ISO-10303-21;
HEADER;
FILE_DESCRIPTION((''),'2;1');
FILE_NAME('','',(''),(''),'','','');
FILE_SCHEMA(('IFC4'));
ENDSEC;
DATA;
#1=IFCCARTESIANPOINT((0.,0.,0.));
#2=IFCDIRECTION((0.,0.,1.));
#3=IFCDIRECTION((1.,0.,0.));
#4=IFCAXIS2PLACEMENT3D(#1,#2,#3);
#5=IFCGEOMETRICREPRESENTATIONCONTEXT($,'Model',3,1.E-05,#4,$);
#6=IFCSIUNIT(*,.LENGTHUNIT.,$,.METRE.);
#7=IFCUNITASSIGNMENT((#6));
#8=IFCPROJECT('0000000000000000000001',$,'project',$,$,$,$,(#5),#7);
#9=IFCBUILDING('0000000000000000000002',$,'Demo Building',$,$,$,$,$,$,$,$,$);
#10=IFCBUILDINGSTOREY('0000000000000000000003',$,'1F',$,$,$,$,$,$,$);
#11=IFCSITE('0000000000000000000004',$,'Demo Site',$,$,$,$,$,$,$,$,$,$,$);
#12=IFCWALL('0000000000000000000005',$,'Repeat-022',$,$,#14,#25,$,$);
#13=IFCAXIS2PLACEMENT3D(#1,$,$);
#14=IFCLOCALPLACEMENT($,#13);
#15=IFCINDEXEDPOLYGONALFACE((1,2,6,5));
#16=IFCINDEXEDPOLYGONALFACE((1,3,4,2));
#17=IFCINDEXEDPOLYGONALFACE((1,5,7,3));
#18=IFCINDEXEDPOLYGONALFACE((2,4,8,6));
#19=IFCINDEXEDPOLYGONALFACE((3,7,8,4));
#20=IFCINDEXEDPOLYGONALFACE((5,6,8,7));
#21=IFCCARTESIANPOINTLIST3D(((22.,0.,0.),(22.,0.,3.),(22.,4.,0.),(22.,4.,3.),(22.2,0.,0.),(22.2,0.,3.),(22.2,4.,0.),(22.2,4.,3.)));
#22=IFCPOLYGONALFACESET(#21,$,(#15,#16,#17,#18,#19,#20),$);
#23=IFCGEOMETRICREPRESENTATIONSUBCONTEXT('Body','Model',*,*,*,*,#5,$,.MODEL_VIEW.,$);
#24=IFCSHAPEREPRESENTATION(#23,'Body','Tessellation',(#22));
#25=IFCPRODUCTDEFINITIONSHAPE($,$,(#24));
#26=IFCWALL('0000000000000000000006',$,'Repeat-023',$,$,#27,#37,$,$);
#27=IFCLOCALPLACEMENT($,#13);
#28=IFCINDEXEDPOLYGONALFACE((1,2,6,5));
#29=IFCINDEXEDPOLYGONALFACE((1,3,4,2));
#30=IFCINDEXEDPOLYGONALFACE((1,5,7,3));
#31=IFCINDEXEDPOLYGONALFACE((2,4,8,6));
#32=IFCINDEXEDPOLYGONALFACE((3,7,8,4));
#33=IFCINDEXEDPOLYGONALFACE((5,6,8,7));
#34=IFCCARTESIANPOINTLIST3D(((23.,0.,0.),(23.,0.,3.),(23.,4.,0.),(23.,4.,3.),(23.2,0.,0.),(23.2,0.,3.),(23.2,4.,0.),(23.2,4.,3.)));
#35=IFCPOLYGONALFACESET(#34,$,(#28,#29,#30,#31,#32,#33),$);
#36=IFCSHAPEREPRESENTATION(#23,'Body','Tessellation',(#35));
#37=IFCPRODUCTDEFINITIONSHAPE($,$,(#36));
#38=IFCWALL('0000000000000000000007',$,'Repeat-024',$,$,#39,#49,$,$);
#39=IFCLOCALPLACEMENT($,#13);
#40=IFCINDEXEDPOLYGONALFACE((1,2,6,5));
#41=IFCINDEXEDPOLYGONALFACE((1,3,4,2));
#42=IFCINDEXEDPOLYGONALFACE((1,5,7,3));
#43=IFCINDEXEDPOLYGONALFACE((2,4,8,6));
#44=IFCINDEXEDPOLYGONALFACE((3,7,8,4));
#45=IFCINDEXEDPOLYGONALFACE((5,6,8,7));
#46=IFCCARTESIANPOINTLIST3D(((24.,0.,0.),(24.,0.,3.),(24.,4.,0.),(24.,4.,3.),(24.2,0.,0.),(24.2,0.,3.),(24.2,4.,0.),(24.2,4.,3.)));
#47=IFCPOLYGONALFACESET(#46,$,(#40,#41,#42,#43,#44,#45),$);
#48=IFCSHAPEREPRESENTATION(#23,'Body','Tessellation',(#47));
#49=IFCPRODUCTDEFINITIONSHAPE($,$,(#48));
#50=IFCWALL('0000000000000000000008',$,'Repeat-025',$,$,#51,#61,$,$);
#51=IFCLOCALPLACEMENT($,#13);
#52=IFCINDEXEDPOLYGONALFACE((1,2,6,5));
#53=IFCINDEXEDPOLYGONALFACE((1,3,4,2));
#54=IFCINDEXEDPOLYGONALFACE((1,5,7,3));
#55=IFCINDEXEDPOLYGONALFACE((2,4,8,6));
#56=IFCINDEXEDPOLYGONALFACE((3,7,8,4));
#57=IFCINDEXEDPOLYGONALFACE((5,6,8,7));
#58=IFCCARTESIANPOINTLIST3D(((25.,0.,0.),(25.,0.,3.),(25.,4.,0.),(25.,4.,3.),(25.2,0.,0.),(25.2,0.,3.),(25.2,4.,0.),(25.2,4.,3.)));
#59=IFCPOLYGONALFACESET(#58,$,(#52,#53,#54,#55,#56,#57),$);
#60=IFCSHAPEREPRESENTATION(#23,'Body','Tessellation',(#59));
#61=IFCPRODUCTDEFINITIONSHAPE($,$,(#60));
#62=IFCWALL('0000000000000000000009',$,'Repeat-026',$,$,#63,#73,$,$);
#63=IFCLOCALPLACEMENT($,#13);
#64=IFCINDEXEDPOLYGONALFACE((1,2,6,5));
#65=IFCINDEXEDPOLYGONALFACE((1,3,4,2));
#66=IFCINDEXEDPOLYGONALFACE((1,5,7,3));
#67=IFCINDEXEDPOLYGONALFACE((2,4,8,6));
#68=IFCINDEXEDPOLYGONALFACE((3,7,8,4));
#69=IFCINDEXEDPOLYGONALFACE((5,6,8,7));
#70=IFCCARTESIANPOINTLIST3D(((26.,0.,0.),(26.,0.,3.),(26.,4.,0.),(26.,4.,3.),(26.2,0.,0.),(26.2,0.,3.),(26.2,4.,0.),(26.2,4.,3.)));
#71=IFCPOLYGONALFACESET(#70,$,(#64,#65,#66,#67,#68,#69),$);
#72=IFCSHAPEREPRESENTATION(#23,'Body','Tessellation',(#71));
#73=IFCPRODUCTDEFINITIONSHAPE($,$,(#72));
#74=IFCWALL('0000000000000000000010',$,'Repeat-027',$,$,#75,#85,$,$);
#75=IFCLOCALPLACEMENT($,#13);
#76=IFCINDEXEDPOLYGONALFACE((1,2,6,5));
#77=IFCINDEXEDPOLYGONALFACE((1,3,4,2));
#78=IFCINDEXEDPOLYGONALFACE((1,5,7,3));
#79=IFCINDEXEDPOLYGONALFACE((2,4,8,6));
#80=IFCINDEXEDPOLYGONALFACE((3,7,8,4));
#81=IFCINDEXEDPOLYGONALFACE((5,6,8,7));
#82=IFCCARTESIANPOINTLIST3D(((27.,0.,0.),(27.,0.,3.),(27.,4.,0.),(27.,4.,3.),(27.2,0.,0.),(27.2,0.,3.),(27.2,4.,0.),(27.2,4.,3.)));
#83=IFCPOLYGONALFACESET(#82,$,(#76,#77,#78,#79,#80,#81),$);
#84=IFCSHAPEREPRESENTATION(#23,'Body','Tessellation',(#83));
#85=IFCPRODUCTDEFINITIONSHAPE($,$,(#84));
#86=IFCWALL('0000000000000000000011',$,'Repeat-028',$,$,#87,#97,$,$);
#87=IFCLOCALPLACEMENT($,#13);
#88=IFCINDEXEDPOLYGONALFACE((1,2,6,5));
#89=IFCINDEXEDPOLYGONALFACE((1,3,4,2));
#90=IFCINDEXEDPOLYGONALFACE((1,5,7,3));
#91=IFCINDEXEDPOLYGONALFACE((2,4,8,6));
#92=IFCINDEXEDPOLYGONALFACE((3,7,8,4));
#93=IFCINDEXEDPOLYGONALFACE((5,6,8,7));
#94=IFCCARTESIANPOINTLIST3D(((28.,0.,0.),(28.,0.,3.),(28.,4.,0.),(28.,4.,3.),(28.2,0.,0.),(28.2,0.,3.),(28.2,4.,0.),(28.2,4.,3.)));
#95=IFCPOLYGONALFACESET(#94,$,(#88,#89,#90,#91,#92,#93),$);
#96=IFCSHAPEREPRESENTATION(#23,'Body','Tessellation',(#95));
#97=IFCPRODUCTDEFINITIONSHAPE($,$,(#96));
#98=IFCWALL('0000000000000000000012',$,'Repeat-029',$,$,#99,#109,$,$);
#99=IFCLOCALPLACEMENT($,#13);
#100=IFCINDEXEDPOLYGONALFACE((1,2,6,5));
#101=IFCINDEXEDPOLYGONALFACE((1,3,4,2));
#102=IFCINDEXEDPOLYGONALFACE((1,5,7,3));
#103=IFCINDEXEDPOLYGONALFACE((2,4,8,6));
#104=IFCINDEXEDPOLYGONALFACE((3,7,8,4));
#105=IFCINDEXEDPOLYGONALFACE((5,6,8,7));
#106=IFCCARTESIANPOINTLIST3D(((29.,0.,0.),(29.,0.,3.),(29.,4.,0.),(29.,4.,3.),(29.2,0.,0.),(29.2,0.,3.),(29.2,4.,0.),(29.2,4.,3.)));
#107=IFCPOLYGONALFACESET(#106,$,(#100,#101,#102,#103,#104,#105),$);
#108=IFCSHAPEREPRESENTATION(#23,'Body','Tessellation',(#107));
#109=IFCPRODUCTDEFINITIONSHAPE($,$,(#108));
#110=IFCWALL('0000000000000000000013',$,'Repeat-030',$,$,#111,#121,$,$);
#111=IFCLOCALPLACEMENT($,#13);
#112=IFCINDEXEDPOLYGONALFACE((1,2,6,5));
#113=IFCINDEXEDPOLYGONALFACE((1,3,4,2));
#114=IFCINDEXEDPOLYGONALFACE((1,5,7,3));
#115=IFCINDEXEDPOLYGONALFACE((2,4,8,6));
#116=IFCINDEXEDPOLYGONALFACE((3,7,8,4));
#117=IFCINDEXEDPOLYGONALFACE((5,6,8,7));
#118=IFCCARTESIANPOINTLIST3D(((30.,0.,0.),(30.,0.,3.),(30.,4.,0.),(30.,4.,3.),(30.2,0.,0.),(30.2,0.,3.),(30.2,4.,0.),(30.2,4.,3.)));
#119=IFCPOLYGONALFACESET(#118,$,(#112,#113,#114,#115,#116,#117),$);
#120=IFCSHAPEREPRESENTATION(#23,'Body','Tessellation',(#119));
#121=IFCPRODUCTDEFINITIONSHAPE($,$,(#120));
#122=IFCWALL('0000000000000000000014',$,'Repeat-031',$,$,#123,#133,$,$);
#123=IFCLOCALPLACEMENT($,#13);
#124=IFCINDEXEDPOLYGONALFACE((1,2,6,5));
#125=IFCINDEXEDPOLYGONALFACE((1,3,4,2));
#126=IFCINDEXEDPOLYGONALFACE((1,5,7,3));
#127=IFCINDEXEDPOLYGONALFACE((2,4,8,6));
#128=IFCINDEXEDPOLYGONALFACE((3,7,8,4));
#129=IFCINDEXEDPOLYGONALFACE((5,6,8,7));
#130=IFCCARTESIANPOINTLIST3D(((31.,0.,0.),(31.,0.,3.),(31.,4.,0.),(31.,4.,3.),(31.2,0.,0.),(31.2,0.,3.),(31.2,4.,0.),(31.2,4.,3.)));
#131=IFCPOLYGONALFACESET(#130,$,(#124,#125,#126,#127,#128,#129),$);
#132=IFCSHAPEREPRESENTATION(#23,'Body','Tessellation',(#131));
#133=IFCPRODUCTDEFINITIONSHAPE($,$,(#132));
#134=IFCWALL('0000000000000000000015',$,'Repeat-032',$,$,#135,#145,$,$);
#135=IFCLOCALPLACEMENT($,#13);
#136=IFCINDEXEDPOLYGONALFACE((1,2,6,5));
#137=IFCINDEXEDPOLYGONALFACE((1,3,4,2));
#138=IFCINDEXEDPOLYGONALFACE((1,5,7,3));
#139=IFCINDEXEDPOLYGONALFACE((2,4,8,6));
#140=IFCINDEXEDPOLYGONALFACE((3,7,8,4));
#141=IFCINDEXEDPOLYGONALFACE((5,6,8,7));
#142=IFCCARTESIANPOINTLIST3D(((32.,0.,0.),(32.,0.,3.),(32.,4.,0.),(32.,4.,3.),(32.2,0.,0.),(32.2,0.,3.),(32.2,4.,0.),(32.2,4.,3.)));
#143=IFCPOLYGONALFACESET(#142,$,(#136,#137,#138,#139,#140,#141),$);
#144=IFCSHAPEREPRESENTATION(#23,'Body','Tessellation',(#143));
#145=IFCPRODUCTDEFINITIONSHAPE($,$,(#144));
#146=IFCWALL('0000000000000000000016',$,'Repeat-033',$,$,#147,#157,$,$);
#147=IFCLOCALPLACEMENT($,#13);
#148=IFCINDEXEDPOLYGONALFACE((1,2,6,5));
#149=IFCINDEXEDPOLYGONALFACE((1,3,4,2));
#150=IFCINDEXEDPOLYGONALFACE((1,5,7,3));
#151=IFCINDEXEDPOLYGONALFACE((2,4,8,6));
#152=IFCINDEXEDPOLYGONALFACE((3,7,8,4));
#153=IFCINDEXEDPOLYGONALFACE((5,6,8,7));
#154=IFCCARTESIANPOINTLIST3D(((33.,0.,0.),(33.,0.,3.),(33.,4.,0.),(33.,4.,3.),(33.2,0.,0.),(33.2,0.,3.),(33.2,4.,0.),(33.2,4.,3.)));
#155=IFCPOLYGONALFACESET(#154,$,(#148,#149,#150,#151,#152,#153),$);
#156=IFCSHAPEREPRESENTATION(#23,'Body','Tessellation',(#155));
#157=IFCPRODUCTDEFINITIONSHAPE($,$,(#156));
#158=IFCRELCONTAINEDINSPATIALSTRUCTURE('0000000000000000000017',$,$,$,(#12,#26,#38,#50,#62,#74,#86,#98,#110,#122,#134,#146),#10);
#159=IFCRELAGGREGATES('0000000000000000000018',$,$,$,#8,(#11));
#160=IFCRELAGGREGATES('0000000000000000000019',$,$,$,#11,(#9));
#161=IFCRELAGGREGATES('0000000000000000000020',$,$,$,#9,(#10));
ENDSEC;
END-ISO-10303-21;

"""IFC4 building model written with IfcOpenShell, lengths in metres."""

from ifc_helpers import new_model, entity, si_unit, frame, origin_with_axes, place, context, subcontext, project, spatial, element, save


model = new_model("IFC4")

# Units and contexts
model_context = context("Model", 3, precision=1e-05, world=origin_with_axes())
body_context = subcontext(model_context, "Body", "Model", "MODEL_VIEW")
ifc_project = project(units=[si_unit("LENGTHUNIT", "METRE")], contexts=[model_context])

# Site, building, storey
site = spatial("IfcSite", under=ifc_project, Name="Demo Site")
building = spatial("IfcBuilding", under=site, Name="Demo Building")
storey = spatial("IfcBuildingStorey", under=building, Name="1F")

# Walls
for number, where, z_axis, x_axis, name in (
    (1, (22.0, 0.0, 0.0), (0.0, 0.0, 1.0), (1.0, 0.0, 0.0), "Repeat-022"),
    (2, (23.0, 0.0, 0.0), (0.0, 0.0, 1.0), (1.0, 0.0, 0.0), "Repeat-023"),
    (3, (24.0, 0.0, 0.0), (0.0, 0.0, 1.0), (1.0, 0.0, 0.0), "Repeat-024"),
    (4, (25.0, 0.0, 0.0), (0.0, 0.0, 1.0), (1.0, 0.0, 0.0), "Repeat-025"),
    (5, (26.0, 0.0, 0.0), (0.0, 0.0, 1.0), (1.0, 0.0, 0.0), "Repeat-026"),
    (6, (27.0, 0.0, 0.0), (0.0, 0.0, 1.0), (1.0, 0.0, 0.0), "Repeat-027"),
    (7, (28.0, 0.0, 0.0), (0.0, 0.0, 1.0), (1.0, 0.0, 0.0), "Repeat-028"),
    (8, (29.0, 0.0, 0.0), (0.0, 0.0, 1.0), (1.0, 0.0, 0.0), "Repeat-029"),
    (9, (30.0, 0.0, 0.0), (0.0, 0.0, 1.0), (1.0, 0.0, 0.0), "Repeat-030"),
    (10, (31.0, 0.0, 0.0), (0.0, 0.0, 1.0), (1.0, 0.0, 0.0), "Repeat-031"),
    (11, (32.0, 0.0, 0.0), (0.0, 0.0, 1.0), (1.0, 0.0, 0.0), "Repeat-032"),
    (12, (33.0, 0.0, 0.0), (0.0, 0.0, 1.0), (1.0, 0.0, 0.0), "Repeat-033"),
):
    element("IfcWall", number, at=place(None, frame(where, z_axis=z_axis, x_axis=x_axis)), inside=storey, Name=name, context=body_context, shape_type="CSG", body=[
        entity("IfcBlock", entity("IfcAxis2Placement3D", entity("IfcCartesianPoint", [0.0, 0.0, 0.0]), entity("IfcDirection", [0.0, 0.0, 1.0]), entity("IfcDirection", [1.0, 0.0, 0.0])), 0.2, 4.0, 3.0),
    ])

save(model, "model.ifc")
